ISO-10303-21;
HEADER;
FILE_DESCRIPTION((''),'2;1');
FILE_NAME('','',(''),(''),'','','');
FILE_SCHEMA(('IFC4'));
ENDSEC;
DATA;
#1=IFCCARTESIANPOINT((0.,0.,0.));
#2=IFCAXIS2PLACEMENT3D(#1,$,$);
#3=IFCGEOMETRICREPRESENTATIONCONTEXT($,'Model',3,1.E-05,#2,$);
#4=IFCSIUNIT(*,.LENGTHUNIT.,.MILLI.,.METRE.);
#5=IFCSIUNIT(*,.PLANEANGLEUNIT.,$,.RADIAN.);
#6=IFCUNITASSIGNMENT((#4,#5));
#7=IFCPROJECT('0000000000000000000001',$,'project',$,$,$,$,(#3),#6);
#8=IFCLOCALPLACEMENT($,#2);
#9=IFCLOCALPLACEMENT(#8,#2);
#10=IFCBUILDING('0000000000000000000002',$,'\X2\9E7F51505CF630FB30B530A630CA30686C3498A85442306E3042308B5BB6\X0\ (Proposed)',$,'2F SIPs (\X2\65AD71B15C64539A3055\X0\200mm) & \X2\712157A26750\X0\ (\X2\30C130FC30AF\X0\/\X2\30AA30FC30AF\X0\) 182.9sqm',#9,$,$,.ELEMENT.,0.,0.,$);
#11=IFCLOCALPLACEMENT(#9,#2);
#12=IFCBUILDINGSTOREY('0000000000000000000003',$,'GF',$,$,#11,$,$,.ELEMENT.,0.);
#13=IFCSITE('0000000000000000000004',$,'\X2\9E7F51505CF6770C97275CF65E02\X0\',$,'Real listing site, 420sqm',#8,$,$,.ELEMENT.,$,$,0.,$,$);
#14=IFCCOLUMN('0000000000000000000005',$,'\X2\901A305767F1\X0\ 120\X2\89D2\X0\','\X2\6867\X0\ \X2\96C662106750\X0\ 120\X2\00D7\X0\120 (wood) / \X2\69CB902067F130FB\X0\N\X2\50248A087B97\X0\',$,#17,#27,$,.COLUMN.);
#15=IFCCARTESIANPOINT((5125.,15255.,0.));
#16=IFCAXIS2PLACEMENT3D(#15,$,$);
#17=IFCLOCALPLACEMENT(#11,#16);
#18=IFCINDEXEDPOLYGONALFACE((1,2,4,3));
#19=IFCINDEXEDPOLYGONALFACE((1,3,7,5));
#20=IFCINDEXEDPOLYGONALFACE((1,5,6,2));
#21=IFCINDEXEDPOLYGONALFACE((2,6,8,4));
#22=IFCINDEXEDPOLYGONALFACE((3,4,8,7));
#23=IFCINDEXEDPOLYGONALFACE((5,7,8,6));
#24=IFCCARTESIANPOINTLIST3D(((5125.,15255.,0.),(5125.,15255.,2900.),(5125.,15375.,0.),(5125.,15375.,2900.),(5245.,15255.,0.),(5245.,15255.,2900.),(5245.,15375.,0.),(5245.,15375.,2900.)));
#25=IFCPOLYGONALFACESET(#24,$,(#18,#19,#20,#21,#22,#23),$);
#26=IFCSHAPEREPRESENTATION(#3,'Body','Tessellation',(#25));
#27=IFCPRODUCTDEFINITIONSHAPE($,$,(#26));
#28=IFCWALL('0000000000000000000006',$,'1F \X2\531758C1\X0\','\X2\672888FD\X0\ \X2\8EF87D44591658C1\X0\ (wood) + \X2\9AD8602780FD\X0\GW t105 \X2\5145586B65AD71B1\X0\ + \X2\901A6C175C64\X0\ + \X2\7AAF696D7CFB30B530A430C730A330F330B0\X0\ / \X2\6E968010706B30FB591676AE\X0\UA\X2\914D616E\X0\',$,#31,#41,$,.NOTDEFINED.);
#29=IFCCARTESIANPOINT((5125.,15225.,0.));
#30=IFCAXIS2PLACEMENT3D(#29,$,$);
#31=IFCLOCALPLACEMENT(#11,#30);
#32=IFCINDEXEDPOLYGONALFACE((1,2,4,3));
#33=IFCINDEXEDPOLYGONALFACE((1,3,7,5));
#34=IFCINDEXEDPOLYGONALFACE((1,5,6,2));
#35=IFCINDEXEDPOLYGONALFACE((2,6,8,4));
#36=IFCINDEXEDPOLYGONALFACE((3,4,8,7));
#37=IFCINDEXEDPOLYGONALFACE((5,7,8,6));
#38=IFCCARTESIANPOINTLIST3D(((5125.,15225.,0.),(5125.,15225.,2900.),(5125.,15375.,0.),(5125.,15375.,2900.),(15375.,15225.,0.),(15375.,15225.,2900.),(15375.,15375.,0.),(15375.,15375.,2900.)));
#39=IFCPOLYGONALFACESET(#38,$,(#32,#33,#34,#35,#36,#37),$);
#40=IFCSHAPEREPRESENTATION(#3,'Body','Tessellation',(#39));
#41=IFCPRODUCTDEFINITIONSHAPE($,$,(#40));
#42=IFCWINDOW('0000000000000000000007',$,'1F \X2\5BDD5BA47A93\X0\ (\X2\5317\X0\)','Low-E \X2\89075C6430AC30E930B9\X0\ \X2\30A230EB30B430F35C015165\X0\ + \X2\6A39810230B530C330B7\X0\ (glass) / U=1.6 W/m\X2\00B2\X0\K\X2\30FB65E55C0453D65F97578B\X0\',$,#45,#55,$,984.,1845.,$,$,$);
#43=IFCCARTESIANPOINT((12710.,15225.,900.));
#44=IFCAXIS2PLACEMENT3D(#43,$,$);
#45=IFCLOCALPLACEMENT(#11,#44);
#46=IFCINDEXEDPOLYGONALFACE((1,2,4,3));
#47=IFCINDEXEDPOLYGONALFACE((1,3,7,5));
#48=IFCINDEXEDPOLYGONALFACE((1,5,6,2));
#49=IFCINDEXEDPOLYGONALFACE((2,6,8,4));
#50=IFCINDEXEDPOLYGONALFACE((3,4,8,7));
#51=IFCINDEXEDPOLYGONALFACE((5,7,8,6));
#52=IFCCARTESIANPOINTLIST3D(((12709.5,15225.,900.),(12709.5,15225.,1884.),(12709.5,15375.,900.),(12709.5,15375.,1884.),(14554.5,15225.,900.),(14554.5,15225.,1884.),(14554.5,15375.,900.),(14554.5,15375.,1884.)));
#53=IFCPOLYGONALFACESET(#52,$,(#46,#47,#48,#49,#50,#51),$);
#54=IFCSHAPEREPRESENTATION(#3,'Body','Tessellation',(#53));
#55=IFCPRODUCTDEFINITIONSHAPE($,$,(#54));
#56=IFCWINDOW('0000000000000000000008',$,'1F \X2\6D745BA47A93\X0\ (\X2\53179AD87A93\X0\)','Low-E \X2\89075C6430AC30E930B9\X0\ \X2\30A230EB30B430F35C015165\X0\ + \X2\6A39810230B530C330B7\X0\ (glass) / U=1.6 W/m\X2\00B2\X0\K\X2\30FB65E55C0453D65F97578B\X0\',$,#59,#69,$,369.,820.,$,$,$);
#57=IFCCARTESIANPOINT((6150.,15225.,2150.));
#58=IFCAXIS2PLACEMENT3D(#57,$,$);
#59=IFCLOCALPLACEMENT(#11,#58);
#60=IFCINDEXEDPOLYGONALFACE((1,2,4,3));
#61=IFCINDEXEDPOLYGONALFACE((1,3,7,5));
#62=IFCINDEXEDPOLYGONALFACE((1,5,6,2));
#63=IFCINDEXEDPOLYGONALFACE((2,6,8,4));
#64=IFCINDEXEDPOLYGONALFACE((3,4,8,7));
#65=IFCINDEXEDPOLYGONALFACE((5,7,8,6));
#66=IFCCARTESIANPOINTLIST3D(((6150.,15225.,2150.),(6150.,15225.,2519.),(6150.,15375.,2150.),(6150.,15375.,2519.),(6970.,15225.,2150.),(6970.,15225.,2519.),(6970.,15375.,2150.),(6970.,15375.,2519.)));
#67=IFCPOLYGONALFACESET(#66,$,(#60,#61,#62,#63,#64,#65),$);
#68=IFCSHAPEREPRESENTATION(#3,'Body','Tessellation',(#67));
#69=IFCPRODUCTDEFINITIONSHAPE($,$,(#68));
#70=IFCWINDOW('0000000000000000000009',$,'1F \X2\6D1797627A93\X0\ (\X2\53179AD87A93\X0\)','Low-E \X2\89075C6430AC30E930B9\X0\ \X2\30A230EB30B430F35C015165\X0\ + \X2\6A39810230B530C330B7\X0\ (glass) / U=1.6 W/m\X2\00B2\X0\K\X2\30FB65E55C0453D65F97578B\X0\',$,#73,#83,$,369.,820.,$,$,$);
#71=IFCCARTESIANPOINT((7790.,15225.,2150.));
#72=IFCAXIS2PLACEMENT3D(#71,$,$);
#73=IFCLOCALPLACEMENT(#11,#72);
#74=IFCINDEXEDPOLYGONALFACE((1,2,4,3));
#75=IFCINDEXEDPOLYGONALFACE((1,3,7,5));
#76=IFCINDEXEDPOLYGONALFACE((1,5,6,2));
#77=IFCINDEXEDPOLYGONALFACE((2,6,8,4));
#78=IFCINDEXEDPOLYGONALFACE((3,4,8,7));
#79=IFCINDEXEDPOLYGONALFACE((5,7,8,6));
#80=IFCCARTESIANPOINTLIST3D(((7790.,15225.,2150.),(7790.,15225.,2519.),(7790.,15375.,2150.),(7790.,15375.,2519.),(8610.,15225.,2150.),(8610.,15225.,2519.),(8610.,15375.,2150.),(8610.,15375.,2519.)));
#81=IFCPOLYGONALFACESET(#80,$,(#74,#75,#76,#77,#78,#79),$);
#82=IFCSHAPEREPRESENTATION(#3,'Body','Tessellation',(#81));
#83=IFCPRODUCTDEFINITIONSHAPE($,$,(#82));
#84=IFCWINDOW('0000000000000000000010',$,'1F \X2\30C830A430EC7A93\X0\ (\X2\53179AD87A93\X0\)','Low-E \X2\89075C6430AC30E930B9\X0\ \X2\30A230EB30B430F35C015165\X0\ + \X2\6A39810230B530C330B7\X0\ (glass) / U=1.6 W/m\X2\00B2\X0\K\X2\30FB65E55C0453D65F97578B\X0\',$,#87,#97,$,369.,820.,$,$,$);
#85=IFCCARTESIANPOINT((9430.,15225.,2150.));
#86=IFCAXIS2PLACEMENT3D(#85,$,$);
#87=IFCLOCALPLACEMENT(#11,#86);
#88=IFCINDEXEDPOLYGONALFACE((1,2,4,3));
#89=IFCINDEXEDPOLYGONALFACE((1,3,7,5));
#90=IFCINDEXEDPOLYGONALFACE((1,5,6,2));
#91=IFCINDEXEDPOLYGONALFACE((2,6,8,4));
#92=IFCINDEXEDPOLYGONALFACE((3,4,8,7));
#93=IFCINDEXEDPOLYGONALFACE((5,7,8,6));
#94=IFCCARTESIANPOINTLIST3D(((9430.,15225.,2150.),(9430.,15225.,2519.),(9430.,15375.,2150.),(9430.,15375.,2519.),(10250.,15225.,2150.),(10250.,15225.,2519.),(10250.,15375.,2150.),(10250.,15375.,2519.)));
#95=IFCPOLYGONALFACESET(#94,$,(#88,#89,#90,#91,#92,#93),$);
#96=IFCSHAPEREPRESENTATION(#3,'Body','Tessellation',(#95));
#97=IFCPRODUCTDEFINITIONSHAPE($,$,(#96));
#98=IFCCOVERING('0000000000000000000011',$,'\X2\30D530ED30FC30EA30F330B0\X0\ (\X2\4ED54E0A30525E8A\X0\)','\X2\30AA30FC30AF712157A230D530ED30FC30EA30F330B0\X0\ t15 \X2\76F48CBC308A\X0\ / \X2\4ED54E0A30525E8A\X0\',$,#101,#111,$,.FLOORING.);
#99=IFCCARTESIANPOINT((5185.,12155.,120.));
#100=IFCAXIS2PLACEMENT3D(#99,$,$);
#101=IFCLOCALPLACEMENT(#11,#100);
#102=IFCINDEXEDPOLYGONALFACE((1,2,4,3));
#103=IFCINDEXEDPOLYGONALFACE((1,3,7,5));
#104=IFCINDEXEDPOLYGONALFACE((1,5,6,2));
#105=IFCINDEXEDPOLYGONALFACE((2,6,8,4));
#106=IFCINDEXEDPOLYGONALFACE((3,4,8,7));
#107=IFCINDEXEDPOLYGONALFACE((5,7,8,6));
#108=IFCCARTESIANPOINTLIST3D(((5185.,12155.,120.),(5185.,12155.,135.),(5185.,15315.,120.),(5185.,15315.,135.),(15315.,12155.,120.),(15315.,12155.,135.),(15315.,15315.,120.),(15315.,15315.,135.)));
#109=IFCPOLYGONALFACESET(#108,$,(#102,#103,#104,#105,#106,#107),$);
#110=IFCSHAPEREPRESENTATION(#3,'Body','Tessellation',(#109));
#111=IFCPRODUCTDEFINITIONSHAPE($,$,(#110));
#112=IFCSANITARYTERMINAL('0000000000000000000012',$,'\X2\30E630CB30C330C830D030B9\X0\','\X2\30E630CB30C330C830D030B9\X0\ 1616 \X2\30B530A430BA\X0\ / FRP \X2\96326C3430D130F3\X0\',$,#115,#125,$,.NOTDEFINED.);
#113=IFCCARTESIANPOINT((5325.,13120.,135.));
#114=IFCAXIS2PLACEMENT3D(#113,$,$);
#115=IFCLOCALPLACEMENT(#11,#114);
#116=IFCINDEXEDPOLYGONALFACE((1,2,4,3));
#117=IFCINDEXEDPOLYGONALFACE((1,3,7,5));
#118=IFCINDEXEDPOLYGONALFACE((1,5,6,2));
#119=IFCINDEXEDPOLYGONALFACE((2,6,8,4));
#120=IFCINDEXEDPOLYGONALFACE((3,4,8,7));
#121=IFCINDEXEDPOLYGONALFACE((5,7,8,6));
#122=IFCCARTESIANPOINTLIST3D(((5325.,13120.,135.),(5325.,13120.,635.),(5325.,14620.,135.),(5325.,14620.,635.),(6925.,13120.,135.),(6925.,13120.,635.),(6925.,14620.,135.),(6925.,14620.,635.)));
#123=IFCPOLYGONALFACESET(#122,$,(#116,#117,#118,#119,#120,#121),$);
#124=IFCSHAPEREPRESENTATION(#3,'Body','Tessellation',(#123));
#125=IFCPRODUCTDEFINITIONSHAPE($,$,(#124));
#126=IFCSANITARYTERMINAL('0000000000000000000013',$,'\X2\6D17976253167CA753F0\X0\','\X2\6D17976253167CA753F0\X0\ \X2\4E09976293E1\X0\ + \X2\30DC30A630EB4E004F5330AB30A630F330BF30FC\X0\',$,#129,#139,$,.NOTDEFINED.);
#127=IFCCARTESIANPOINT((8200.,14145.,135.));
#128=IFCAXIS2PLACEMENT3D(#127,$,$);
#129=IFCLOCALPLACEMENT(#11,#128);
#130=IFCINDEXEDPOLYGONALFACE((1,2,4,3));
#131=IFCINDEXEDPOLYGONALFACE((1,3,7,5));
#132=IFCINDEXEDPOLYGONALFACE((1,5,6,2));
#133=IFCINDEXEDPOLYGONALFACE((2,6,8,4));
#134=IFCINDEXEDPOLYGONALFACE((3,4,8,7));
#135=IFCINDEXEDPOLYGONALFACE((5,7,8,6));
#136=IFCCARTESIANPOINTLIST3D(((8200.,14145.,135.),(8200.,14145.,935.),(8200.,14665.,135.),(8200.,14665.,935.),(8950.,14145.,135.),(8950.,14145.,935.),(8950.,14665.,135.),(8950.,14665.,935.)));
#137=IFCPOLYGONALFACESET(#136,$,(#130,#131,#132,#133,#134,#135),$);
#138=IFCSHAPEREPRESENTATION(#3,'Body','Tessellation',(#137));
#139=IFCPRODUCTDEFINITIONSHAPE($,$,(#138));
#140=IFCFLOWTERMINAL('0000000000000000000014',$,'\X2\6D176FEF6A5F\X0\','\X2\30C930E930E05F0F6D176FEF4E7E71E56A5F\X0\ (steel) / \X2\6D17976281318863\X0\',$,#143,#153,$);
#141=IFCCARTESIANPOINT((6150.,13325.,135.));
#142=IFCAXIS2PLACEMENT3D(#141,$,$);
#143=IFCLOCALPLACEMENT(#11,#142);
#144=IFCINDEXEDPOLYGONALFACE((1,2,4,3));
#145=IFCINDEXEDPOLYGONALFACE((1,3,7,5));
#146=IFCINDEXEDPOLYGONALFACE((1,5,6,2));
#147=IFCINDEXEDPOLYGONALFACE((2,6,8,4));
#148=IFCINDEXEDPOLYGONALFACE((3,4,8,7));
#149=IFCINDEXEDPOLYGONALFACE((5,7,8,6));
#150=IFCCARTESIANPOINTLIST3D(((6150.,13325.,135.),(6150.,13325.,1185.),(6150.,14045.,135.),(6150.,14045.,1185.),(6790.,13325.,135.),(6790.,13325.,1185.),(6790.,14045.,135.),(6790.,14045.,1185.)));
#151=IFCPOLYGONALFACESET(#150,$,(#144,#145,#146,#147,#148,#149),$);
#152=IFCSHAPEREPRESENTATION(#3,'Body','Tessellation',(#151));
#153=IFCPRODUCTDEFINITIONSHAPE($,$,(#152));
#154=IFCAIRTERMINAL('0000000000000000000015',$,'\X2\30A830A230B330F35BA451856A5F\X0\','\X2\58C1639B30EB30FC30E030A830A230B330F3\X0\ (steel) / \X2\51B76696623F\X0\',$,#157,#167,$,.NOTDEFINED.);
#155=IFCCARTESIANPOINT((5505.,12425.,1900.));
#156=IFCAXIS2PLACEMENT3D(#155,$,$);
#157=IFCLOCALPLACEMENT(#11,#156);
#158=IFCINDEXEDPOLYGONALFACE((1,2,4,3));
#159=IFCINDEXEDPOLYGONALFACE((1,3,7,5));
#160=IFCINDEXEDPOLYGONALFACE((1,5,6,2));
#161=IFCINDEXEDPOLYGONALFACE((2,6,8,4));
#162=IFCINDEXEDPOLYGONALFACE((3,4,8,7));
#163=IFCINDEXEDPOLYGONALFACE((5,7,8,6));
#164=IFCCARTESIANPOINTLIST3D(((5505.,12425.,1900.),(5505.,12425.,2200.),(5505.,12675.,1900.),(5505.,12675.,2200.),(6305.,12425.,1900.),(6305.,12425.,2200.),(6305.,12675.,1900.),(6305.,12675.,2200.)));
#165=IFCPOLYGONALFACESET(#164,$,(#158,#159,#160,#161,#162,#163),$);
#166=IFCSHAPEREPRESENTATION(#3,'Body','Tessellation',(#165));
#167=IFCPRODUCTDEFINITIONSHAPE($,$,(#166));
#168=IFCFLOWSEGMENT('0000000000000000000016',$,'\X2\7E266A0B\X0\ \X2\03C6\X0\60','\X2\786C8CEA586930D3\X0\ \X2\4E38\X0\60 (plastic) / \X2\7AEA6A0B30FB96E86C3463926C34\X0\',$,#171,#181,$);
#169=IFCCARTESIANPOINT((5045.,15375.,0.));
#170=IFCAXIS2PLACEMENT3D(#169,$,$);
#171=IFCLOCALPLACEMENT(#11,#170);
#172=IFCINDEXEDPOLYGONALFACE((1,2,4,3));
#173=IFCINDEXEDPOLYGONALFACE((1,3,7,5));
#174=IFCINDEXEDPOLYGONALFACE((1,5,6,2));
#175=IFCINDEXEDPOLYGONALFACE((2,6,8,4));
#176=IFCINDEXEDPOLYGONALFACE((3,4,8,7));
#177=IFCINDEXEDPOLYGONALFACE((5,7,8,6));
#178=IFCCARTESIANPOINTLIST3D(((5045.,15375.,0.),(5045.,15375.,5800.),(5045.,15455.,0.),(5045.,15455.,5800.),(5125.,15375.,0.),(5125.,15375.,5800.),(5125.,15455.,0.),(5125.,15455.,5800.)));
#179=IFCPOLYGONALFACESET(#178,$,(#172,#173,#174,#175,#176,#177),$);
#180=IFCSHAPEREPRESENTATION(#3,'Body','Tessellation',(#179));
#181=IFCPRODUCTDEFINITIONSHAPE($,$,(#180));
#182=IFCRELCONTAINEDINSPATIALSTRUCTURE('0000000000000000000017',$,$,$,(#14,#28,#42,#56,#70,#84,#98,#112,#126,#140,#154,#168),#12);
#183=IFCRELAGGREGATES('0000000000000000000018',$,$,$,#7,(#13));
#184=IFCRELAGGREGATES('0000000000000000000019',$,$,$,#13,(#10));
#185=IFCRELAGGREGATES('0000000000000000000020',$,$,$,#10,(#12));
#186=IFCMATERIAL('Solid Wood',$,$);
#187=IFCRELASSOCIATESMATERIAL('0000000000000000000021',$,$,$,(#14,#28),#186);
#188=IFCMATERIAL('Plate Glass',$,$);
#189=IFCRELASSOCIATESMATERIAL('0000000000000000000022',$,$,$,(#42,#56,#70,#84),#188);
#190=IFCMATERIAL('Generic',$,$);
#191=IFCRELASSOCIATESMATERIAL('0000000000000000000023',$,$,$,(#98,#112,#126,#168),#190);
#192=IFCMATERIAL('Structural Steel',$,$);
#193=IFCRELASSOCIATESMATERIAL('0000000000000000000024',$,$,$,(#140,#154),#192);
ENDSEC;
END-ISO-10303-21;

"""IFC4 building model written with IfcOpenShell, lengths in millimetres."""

from ifc_helpers import new_model, si_unit, frame, frame_2d, origin, place, context, project, spatial, rectangle, extrude, material, element, fill, save


model = new_model("IFC4")

# Units and contexts
model_context = context("Model", 3, precision=1e-05, world=origin())
ifc_project = project(units=[si_unit("LENGTHUNIT", "METRE", prefix="MILLI"), si_unit("PLANEANGLEUNIT", "RADIAN")], contexts=[model_context])

# Site, building, storey
site_placement = place(None, origin())
site = spatial("IfcSite", under=ifc_project, at=site_placement, Name="鹿児島県霧島市", ObjectType="Real listing site, 420sqm", CompositionType="ELEMENT", RefElevation=0.0)
building_placement = place(site_placement, origin())
building = spatial("IfcBuilding", under=site, at=building_placement, Name="鹿児島・サウナと水風呂のある家 (Proposed)", ObjectType="2F SIPs (断熱層厚さ200mm) & 無垢材 (チーク/オーク) 182.9sqm", CompositionType="ELEMENT", ElevationOfRefHeight=0.0, ElevationOfTerrain=0.0)
storey_placement = place(building_placement, origin())
storey = spatial("IfcBuildingStorey", under=building, at=storey_placement, Name="GF", CompositionType="ELEMENT", Elevation=0.0)

# Column
ifc_material_1 = material(Name="Solid Wood")
column_1_placement = place(storey_placement, frame((5125.0, 15255.0, 0.0)))
element("IfcColumn", 1, at=column_1_placement, inside=storey, material=ifc_material_1, Name="通し柱 120角", Description="桧 集成材 120×120 (wood) / 構造柱・N値計算", PredefinedType="COLUMN", context=model_context, shape_type="SweptSolid", body=[
    extrude(rectangle(XDim=120.0, YDim=120.0, at=frame_2d((60.0, 60.0))), frame((5125.0, 15255.0, 0.0)), (0.0, 0.0, 1.0), 2900.0),
])

# Wall, openings, windows
wall_1_placement = place(storey_placement, frame((5125.0, 15225.0, 0.0)))
wall_1 = element("IfcWall", 2, at=wall_1_placement, inside=storey, material=ifc_material_1, Name="1F 北壁", Description="木製 軸組外壁 (wood) + 高性能GW t105 充填断熱 + 通気層 + 窯業系サイディング / 準耐火・外皮UA配慮", PredefinedType="NOTDEFINED", context=model_context, shape_type="SweptSolid", body=[
    extrude(rectangle(XDim=10250.0, YDim=150.0, at=frame_2d((5125.0, 75.0))), frame((5125.0, 15225.0, 0.0)), (0.0, 0.0, 1.0), 2900.0),
])
opening_1_placement = place(storey_placement, frame((12710.0, 15225.0, 900.0)))
opening_1 = element("IfcOpeningElement", 3, at=opening_1_placement, cuts=wall_1, PredefinedType="NOTDEFINED", context=model_context, shape_type="SweptSolid", body=[
    extrude(rectangle(XDim=1845.0, YDim=150.0, at=frame_2d((922.0, 75.0))), frame((12710.0, 15225.0, 900.0)), (0.0, 0.0, 1.0), 984.0),
])
opening_2_placement = place(storey_placement, frame((6150.0, 15225.0, 2150.0)))
opening_2 = element("IfcOpeningElement", 4, at=opening_2_placement, cuts=wall_1, PredefinedType="NOTDEFINED", context=model_context, shape_type="SweptSolid", body=[
    extrude(rectangle(XDim=820.0, YDim=150.0, at=frame_2d((410.0, 75.0))), frame((6150.0, 15225.0, 2150.0)), (0.0, 0.0, 1.0), 369.0),
])
opening_3_placement = place(storey_placement, frame((7790.0, 15225.0, 2150.0)))
opening_3 = element("IfcOpeningElement", 5, at=opening_3_placement, cuts=wall_1, PredefinedType="NOTDEFINED", context=model_context, shape_type="SweptSolid", body=[
    extrude(rectangle(XDim=820.0, YDim=150.0, at=frame_2d((410.0, 75.0))), frame((7790.0, 15225.0, 2150.0)), (0.0, 0.0, 1.0), 369.0),
])
opening_4_placement = place(storey_placement, frame((9430.0, 15225.0, 2150.0)))
opening_4 = element("IfcOpeningElement", 6, at=opening_4_placement, cuts=wall_1, PredefinedType="NOTDEFINED", context=model_context, shape_type="SweptSolid", body=[
    extrude(rectangle(XDim=820.0, YDim=150.0, at=frame_2d((410.0, 75.0))), frame((9430.0, 15225.0, 2150.0)), (0.0, 0.0, 1.0), 369.0),
])
ifc_material_2 = material(Name="Plate Glass")
window_1_placement = place(storey_placement, frame((12710.0, 15225.0, 900.0)))
window_1 = element("IfcWindow", 7, at=window_1_placement, inside=storey, material=ifc_material_2, Name="1F 寝室窓 (北)", Description="Low-E 複層ガラス アルゴン封入 + 樹脂サッシ (glass) / U=1.6 W/m²K・日射取得型", OverallHeight=984.0, OverallWidth=1845.0, context=model_context, shape_type="SweptSolid", body=[
    extrude(rectangle(XDim=1845.0, YDim=150.0, at=frame_2d((922.0, 75.0))), frame((12710.0, 15225.0, 900.0)), (0.0, 0.0, 1.0), 984.0),
])
fill(opening_1, window_1)
window_2_placement = place(storey_placement, frame((6150.0, 15225.0, 2150.0)))
window_2 = element("IfcWindow", 8, at=window_2_placement, inside=storey, material=ifc_material_2, Name="1F 浴室窓 (北高窓)", Description="Low-E 複層ガラス アルゴン封入 + 樹脂サッシ (glass) / U=1.6 W/m²K・日射取得型", OverallHeight=369.0, OverallWidth=820.0, context=model_context, shape_type="SweptSolid", body=[
    extrude(rectangle(XDim=820.0, YDim=150.0, at=frame_2d((410.0, 75.0))), frame((6150.0, 15225.0, 2150.0)), (0.0, 0.0, 1.0), 369.0),
])
fill(opening_2, window_2)
window_3_placement = place(storey_placement, frame((7790.0, 15225.0, 2150.0)))
window_3 = element("IfcWindow", 9, at=window_3_placement, inside=storey, material=ifc_material_2, Name="1F 洗面窓 (北高窓)", Description="Low-E 複層ガラス アルゴン封入 + 樹脂サッシ (glass) / U=1.6 W/m²K・日射取得型", OverallHeight=369.0, OverallWidth=820.0, context=model_context, shape_type="SweptSolid", body=[
    extrude(rectangle(XDim=820.0, YDim=150.0, at=frame_2d((410.0, 75.0))), frame((7790.0, 15225.0, 2150.0)), (0.0, 0.0, 1.0), 369.0),
])
fill(opening_3, window_3)
window_4_placement = place(storey_placement, frame((9430.0, 15225.0, 2150.0)))
window_4 = element("IfcWindow", 10, at=window_4_placement, inside=storey, material=ifc_material_2, Name="1F トイレ窓 (北高窓)", Description="Low-E 複層ガラス アルゴン封入 + 樹脂サッシ (glass) / U=1.6 W/m²K・日射取得型", OverallHeight=369.0, OverallWidth=820.0, context=model_context, shape_type="SweptSolid", body=[
    extrude(rectangle(XDim=820.0, YDim=150.0, at=frame_2d((410.0, 75.0))), frame((9430.0, 15225.0, 2150.0)), (0.0, 0.0, 1.0), 369.0),
])
fill(opening_4, window_4)

# Covering
ifc_material_3 = material(Name="Generic")
covering_placement = place(storey_placement, frame((5185.0, 12155.0, 120.0)))
element("IfcCovering", 11, at=covering_placement, inside=storey, material=ifc_material_3, Name="フローリング (仕上げ床)", Description="オーク無垢フローリング t15 直貼り / 仕上げ床", PredefinedType="FLOORING", context=model_context, shape_type="SweptSolid", body=[
    extrude(rectangle(XDim=10130.0, YDim=3160.0, at=frame_2d((5065.0, 1580.0))), frame((5185.0, 12155.0, 120.0)), (0.0, 0.0, 1.0), 15.0),
])

# Sanitary terminals
sanitary_terminal_1_placement = place(storey_placement, frame((5325.0, 13120.0, 135.0)))
element("IfcSanitaryTerminal", 12, at=sanitary_terminal_1_placement, inside=storey, material=ifc_material_3, Name="ユニットバス", Description="ユニットバス 1616 サイズ / FRP 防水パン", PredefinedType="NOTDEFINED", context=model_context, shape_type="SweptSolid", body=[
    extrude(rectangle(XDim=1600.0, YDim=1500.0, at=frame_2d((800.0, 750.0))), frame((5325.0, 13120.0, 135.0)), (0.0, 0.0, 1.0), 500.0),
])
sanitary_terminal_2_placement = place(storey_placement, frame((8200.0, 14145.0, 135.0)))
element("IfcSanitaryTerminal", 13, at=sanitary_terminal_2_placement, inside=storey, material=ifc_material_3, Name="洗面化粧台", Description="洗面化粧台 三面鏡 + ボウル一体カウンター", PredefinedType="NOTDEFINED", context=model_context, shape_type="SweptSolid", body=[
    extrude(rectangle(XDim=750.0, YDim=520.0, at=frame_2d((375.0, 260.0))), frame((8200.0, 14145.0, 135.0)), (0.0, 0.0, 1.0), 800.0),
])

# Flow terminal
ifc_material_4 = material(Name="Structural Steel")
flow_terminal_placement = place(storey_placement, frame((6150.0, 13325.0, 135.0)))
element("IfcFlowTerminal", 14, at=flow_terminal_placement, inside=storey, material=ifc_material_4, Name="洗濯機", Description="ドラム式洗濯乾燥機 (steel) / 洗面脱衣", context=model_context, shape_type="SweptSolid", body=[
    extrude(rectangle(XDim=640.0, YDim=720.0, at=frame_2d((320.0, 360.0))), frame((6150.0, 13325.0, 135.0)), (0.0, 0.0, 1.0), 1050.0),
])

# Air terminal
air_terminal_placement = place(storey_placement, frame((5505.0, 12425.0, 1900.0)))
element("IfcAirTerminal", 15, at=air_terminal_placement, inside=storey, material=ifc_material_4, Name="エアコン室内機", Description="壁掛ルームエアコン (steel) / 冷暖房", PredefinedType="NOTDEFINED", context=model_context, shape_type="SweptSolid", body=[
    extrude(rectangle(XDim=800.0, YDim=250.0, at=frame_2d((400.0, 125.0))), frame((5505.0, 12425.0, 1900.0)), (0.0, 0.0, 1.0), 300.0),
])

# Flow segment
flow_segment_placement = place(storey_placement, frame((5045.0, 15375.0, 0.0)))
element("IfcFlowSegment", 16, at=flow_segment_placement, inside=storey, material=ifc_material_3, Name="縦樋 φ60", Description="硬質塩ビ 丸60 (plastic) / 竪樋・雨水排水", context=model_context, shape_type="SweptSolid", body=[
    extrude(rectangle(XDim=80.0, YDim=80.0, at=frame_2d((40.0, 40.0))), frame((5045.0, 15375.0, 0.0)), (0.0, 0.0, 1.0), 5800.0),
])

save(model, "model.ifc")
